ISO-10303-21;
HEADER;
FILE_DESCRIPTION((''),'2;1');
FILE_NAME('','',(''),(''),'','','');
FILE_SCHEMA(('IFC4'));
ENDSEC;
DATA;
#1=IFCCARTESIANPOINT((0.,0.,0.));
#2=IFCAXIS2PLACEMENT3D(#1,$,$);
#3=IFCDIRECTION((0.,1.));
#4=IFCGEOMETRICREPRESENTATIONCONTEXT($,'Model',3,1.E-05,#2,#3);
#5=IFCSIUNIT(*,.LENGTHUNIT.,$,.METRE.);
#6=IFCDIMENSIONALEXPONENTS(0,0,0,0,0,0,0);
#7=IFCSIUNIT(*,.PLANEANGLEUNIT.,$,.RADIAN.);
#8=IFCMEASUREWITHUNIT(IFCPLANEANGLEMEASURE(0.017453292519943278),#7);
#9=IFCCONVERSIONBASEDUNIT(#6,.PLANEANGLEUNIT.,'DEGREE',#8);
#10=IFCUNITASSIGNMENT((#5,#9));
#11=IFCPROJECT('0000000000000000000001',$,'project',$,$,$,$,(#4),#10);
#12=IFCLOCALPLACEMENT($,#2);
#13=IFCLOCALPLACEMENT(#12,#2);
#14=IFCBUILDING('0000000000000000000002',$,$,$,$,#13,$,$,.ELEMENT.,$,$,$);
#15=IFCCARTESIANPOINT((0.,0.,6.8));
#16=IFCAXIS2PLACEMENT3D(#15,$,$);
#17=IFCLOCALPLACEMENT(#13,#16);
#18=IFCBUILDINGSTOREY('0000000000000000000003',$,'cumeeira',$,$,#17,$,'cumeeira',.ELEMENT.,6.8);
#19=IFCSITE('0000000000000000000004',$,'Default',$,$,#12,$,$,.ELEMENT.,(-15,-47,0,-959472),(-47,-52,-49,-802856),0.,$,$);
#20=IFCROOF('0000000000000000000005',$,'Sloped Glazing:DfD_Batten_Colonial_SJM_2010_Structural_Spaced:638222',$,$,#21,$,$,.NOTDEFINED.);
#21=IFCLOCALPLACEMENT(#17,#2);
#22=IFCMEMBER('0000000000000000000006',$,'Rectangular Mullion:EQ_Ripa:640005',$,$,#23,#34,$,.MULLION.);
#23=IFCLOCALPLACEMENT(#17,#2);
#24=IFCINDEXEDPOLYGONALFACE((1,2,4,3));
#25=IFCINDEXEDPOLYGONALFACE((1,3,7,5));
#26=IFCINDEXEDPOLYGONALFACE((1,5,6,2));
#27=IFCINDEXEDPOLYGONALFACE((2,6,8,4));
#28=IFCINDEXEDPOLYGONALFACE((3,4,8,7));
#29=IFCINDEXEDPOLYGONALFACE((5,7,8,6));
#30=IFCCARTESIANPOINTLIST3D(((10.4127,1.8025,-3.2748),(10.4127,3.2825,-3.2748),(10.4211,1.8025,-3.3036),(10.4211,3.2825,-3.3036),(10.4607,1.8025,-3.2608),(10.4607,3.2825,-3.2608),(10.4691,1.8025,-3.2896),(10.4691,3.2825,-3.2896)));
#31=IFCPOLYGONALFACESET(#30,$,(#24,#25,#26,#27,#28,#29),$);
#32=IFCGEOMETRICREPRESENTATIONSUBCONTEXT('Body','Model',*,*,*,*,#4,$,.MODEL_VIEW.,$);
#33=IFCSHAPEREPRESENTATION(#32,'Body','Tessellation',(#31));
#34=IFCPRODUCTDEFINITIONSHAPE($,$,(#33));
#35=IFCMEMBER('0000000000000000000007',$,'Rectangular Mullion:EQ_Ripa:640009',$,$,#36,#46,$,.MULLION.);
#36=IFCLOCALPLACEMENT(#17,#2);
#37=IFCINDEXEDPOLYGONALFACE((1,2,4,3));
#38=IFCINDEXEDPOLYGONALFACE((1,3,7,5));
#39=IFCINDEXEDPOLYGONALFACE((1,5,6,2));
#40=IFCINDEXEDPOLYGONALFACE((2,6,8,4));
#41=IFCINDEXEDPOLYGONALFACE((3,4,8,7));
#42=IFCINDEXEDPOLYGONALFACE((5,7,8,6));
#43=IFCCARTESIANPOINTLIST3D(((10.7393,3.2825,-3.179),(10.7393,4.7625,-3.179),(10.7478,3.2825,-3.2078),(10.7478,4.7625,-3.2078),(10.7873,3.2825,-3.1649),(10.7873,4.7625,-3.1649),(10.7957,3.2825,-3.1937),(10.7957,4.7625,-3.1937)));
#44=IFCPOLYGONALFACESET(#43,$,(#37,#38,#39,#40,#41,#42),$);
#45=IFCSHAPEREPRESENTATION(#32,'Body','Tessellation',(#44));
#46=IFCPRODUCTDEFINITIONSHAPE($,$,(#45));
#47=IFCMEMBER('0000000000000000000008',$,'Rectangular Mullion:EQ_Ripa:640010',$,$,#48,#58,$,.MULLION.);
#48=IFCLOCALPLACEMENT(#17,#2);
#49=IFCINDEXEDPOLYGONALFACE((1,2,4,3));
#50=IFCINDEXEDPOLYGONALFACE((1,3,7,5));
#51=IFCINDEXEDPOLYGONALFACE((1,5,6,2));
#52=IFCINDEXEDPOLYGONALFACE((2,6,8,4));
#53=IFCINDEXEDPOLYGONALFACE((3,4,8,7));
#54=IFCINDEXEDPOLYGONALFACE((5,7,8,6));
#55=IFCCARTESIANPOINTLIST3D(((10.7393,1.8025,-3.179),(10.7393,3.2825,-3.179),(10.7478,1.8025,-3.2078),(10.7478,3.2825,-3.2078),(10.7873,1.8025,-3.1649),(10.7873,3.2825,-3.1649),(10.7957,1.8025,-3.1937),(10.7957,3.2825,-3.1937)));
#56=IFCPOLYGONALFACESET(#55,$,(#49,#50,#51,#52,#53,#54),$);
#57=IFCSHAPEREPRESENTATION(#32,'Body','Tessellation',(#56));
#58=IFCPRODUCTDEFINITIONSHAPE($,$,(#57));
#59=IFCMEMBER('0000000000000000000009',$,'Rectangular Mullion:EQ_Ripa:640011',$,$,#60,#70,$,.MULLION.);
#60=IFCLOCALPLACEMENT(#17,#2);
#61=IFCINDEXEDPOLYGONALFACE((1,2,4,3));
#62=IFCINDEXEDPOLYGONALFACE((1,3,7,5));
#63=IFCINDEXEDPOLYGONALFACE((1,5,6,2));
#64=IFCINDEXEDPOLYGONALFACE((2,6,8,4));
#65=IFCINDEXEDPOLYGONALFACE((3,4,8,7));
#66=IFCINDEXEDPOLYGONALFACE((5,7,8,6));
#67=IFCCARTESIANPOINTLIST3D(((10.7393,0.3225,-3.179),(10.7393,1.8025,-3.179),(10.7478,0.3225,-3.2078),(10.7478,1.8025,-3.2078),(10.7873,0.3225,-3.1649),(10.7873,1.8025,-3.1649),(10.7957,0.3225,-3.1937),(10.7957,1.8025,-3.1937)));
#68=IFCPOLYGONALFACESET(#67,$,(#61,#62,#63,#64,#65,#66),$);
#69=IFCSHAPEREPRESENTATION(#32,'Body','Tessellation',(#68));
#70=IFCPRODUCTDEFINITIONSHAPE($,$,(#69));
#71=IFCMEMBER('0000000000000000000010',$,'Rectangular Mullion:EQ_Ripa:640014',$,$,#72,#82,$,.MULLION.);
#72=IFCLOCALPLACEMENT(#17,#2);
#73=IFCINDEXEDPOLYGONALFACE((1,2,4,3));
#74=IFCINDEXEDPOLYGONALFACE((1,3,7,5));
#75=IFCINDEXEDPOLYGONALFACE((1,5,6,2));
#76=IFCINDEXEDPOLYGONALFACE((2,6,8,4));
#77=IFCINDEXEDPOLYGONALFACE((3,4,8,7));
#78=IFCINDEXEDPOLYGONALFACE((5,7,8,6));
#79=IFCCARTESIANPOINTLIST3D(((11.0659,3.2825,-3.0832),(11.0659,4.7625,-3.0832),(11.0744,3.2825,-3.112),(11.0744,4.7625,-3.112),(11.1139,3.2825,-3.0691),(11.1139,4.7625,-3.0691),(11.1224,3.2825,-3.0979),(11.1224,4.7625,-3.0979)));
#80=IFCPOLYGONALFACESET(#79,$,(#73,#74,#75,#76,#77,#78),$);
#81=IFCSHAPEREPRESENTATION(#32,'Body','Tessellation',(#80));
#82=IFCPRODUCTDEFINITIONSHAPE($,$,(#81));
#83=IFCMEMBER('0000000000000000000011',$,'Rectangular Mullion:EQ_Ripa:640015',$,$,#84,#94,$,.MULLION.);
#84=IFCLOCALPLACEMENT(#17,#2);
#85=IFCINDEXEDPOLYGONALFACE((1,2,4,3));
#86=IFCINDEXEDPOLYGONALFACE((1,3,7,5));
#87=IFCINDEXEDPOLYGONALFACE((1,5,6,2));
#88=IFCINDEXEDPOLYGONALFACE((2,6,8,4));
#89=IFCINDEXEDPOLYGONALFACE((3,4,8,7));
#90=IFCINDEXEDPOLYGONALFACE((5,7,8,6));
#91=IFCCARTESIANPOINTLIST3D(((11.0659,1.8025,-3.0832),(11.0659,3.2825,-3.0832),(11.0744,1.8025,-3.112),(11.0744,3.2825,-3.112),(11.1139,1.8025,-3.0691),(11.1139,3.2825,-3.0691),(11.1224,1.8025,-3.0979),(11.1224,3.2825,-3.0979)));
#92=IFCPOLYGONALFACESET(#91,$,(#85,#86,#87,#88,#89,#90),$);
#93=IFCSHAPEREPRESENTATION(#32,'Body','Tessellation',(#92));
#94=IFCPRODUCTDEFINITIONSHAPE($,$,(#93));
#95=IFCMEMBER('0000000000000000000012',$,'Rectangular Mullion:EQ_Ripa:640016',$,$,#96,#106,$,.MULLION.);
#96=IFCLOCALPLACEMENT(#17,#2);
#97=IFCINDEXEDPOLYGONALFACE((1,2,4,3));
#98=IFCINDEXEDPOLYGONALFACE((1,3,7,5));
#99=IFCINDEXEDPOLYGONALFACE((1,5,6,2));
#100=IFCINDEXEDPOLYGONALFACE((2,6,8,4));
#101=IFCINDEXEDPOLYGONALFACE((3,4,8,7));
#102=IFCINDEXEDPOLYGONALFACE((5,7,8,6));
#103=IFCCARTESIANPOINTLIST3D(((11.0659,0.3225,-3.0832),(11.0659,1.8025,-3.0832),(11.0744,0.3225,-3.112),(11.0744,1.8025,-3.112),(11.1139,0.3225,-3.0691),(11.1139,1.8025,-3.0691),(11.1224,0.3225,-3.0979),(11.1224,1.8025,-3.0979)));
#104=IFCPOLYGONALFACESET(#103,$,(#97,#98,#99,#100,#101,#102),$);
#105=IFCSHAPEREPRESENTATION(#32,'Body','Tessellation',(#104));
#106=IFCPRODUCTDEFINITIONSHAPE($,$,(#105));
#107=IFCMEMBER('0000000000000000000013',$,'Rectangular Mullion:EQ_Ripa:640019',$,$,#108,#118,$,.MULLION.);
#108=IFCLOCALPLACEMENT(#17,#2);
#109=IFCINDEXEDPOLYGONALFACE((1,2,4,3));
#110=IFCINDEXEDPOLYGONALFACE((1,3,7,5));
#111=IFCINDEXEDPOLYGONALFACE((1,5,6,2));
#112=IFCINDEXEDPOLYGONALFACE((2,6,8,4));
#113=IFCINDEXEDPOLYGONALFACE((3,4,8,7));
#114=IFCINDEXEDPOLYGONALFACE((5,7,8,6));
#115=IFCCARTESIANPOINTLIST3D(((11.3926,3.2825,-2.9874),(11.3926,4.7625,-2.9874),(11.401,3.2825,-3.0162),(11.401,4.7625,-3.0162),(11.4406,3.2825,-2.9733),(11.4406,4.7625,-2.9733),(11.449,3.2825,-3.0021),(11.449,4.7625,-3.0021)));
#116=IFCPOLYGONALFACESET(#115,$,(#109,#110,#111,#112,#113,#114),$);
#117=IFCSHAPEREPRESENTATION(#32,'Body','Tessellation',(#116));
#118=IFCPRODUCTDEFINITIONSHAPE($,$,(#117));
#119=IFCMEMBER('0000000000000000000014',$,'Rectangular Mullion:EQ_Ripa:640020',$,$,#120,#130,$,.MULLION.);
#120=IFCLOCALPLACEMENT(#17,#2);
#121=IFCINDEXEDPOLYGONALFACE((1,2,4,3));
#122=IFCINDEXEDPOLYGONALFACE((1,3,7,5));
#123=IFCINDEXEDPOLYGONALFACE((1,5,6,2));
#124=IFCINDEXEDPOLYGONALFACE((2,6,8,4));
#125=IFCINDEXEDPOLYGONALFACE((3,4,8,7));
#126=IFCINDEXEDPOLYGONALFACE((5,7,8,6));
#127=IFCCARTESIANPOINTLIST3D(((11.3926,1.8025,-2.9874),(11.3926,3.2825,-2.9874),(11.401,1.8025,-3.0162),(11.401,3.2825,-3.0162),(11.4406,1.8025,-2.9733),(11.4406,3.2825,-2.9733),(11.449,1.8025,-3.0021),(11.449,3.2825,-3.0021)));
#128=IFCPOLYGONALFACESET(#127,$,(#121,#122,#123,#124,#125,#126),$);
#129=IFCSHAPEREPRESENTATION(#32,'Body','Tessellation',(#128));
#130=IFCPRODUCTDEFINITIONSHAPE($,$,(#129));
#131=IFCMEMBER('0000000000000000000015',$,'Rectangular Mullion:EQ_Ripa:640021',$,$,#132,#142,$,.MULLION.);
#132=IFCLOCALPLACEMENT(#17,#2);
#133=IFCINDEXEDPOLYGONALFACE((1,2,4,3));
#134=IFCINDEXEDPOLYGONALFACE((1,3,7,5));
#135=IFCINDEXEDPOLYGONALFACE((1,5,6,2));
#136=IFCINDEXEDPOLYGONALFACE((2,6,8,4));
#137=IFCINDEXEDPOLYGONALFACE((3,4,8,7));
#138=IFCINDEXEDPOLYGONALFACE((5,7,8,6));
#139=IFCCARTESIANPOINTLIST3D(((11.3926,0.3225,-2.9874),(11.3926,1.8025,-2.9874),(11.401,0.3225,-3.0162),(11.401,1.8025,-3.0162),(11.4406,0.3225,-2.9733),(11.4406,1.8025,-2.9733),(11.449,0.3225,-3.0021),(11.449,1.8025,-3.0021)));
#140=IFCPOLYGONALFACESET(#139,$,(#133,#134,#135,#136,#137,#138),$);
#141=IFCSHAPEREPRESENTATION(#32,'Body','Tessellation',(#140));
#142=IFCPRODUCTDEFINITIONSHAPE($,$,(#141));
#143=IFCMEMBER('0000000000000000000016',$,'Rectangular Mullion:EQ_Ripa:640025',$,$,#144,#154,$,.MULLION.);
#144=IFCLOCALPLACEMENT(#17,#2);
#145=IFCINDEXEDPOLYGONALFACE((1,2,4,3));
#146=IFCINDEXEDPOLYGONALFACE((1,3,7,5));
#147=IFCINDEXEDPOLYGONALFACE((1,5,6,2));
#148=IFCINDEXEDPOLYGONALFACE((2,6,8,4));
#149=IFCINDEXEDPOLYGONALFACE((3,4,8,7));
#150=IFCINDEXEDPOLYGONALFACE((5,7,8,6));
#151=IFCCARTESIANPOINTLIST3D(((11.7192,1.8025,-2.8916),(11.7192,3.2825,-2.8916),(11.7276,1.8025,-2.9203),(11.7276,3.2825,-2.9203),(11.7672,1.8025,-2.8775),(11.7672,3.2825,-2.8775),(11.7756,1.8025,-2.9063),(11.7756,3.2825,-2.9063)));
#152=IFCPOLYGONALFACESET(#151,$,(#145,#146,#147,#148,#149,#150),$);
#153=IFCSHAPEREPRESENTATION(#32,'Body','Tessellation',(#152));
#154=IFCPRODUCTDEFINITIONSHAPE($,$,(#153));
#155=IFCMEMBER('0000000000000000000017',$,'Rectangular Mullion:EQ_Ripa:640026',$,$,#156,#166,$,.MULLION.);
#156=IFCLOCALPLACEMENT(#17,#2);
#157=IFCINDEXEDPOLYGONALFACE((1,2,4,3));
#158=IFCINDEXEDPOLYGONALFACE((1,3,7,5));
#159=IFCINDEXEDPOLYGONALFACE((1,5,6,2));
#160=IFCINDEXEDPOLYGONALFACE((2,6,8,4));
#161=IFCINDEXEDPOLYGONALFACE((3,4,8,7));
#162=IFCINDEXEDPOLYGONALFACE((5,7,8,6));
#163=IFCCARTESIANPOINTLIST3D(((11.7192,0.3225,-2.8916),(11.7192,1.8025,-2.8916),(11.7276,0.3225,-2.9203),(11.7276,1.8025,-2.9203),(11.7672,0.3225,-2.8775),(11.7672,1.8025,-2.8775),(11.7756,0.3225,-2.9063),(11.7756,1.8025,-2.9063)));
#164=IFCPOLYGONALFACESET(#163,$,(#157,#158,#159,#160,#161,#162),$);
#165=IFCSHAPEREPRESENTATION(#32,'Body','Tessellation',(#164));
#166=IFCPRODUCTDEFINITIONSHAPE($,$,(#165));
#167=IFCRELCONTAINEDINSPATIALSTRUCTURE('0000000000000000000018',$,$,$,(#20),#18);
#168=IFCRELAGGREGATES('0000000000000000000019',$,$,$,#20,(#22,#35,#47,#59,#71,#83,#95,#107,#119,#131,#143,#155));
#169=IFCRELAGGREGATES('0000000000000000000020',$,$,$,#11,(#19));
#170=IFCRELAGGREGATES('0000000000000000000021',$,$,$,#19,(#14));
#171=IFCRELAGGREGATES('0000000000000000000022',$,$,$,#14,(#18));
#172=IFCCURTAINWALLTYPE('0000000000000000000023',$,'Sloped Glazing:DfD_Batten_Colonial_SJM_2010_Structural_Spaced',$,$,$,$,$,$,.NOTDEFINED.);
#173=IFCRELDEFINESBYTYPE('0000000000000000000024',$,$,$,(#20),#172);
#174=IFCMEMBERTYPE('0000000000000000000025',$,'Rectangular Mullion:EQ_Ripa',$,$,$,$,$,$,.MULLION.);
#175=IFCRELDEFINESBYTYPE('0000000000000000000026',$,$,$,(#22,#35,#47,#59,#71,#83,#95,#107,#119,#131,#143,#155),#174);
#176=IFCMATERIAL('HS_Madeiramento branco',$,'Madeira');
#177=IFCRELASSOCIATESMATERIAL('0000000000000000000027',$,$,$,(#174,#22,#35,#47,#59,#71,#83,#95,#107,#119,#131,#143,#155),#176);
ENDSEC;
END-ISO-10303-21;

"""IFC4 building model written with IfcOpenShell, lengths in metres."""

from ifc_helpers import new_model, entity, si_unit, converted_unit, direction, frame, origin, place, context, subcontext, project, spatial, indexed_curve, outline, extrude, source, transform, mapped, material, type_object, type_shapes, element, aggregate, save


model = new_model("IFC4")

# Units and contexts
model_context = context("Model", 3, precision=1e-05, world=origin(), true_north=direction((0.0, 1.0)))
body_context = subcontext(model_context, "Body", "Model", "MODEL_VIEW")
ifc_project = project(units=[si_unit("LENGTHUNIT", "METRE"), converted_unit("PLANEANGLEUNIT", "DEGREE", entity("IfcPlaneAngleMeasure", 0.017453292519943278), si_unit("PLANEANGLEUNIT", "RADIAN"), dimensions=[0, 0, 0, 0, 0, 0, 0])], contexts=[model_context])

# Site, building, storey
site_placement = place(None, origin())
site = spatial("IfcSite", under=ifc_project, at=site_placement, Name="Default", CompositionType="ELEMENT", RefLatitude=(-15, -47, 0, -959472), RefLongitude=(-47, -52, -49, -802856), RefElevation=0.0)
building_placement = place(site_placement, origin())
building = spatial("IfcBuilding", under=site, at=building_placement, CompositionType="ELEMENT")
storey_placement = place(building_placement, frame((0.0, 0.0, 6.8)))
storey = spatial("IfcBuildingStorey", under=building, at=storey_placement, Name="cumeeira", LongName="cumeeira", CompositionType="ELEMENT", Elevation=6.8)

# Roof, members
curtain_wall_type = type_object("IfcCurtainWallType", Name="Sloped Glazing:DfD_Batten_Colonial_SJM_2010_Structural_Spaced", PredefinedType="NOTDEFINED")
roof_placement = place(storey_placement, frame((0.0, 0.0, -6.8)))
roof = element("IfcRoof", 1, at=roof_placement, inside=storey, type_object=curtain_wall_type, Name="Sloped Glazing:DfD_Batten_Colonial_SJM_2010_Structural_Spaced:638222", PredefinedType="NOTDEFINED")
ifc_material = material(Name="HS_Madeiramento branco", Category="Madeira")
member_type_1 = type_object("IfcMemberType", Name="Rectangular Mullion:EQ_Ripa", PredefinedType="MULLION", material=ifc_material)
shared_shape_1 = source(origin(), body_context, "Body", "SweptSolid", [
    extrude(outline(indexed_curve([(-0.025, -0.015), (0.025, -0.015), (0.025, 0.015), (-0.025, 0.015), (-0.025, -0.015)], self_intersect=False)), frame((0.0, 0.0, -1.48), z_axis=(0.0, 0.0, 1.0), x_axis=(-1.0, 0.0, 0.0)), (0.0, 0.0, 1.0), 1.48),
])
type_shapes(member_type_1, [shared_shape_1])
member_1_placement = place(roof_placement, frame((10.4409, 3.2825, 3.5178), z_axis=(0.0, 1.0, 0.0), x_axis=(0.95956, 0.0, 0.281504)))
member_1 = element("IfcMember", 2, at=member_1_placement, type_object=member_type_1, material=ifc_material, Name="Rectangular Mullion:EQ_Ripa:640005", PredefinedType="MULLION", context=body_context, shape_type="MappedRepresentation", body=[
    mapped(shared_shape_1, transform((0.0, 0.0, 0.0), scale=1.0)),
])
member_2_placement = place(roof_placement, frame((10.7675, 4.7625, 3.6136), z_axis=(0.0, 1.0, 0.0), x_axis=(0.95956, 0.0, 0.281504)))
member_2 = element("IfcMember", 3, at=member_2_placement, type_object=member_type_1, material=ifc_material, Name="Rectangular Mullion:EQ_Ripa:640009", PredefinedType="MULLION", context=body_context, shape_type="MappedRepresentation", body=[
    mapped(shared_shape_1, transform((0.0, 0.0, 0.0), scale=1.0)),
])
member_3_placement = place(roof_placement, frame((10.7675, 3.2825, 3.6136), z_axis=(0.0, 1.0, 0.0), x_axis=(0.95956, 0.0, 0.281504)))
member_3 = element("IfcMember", 4, at=member_3_placement, type_object=member_type_1, material=ifc_material, Name="Rectangular Mullion:EQ_Ripa:640010", PredefinedType="MULLION", context=body_context, shape_type="MappedRepresentation", body=[
    mapped(shared_shape_1, transform((0.0, 0.0, 0.0), scale=1.0)),
])
member_4_placement = place(roof_placement, frame((10.7675, 1.8025, 3.6136), z_axis=(0.0, 1.0, 0.0), x_axis=(0.95956, 0.0, 0.281504)))
member_4 = element("IfcMember", 5, at=member_4_placement, type_object=member_type_1, material=ifc_material, Name="Rectangular Mullion:EQ_Ripa:640011", PredefinedType="MULLION", context=body_context, shape_type="MappedRepresentation", body=[
    mapped(shared_shape_1, transform((0.0, 0.0, 0.0), scale=1.0)),
])
member_5_placement = place(roof_placement, frame((11.0942, 4.7625, 3.7094), z_axis=(0.0, 1.0, 0.0), x_axis=(0.95956, 0.0, 0.281504)))
member_5 = element("IfcMember", 6, at=member_5_placement, type_object=member_type_1, material=ifc_material, Name="Rectangular Mullion:EQ_Ripa:640014", PredefinedType="MULLION", context=body_context, shape_type="MappedRepresentation", body=[
    mapped(shared_shape_1, transform((0.0, 0.0, 0.0), scale=1.0)),
])
member_6_placement = place(roof_placement, frame((11.0942, 3.2825, 3.7094), z_axis=(0.0, 1.0, 0.0), x_axis=(0.95956, 0.0, 0.281504)))
member_6 = element("IfcMember", 7, at=member_6_placement, type_object=member_type_1, material=ifc_material, Name="Rectangular Mullion:EQ_Ripa:640015", PredefinedType="MULLION", context=body_context, shape_type="MappedRepresentation", body=[
    mapped(shared_shape_1, transform((0.0, 0.0, 0.0), scale=1.0)),
])
member_7_placement = place(roof_placement, frame((11.0942, 1.8025, 3.7094), z_axis=(0.0, 1.0, 0.0), x_axis=(0.95956, 0.0, 0.281504)))
member_7 = element("IfcMember", 8, at=member_7_placement, type_object=member_type_1, material=ifc_material, Name="Rectangular Mullion:EQ_Ripa:640016", PredefinedType="MULLION", context=body_context, shape_type="MappedRepresentation", body=[
    mapped(shared_shape_1, transform((0.0, 0.0, 0.0), scale=1.0)),
])
member_8_placement = place(roof_placement, frame((11.4208, 4.7625, 3.8053), z_axis=(0.0, 1.0, 0.0), x_axis=(0.95956, 0.0, 0.281504)))
member_8 = element("IfcMember", 9, at=member_8_placement, type_object=member_type_1, material=ifc_material, Name="Rectangular Mullion:EQ_Ripa:640019", PredefinedType="MULLION", context=body_context, shape_type="MappedRepresentation", body=[
    mapped(shared_shape_1, transform((0.0, 0.0, 0.0), scale=1.0)),
])
member_9_placement = place(roof_placement, frame((11.4208, 3.2825, 3.8053), z_axis=(0.0, 1.0, 0.0), x_axis=(0.95956, 0.0, 0.281504)))
member_9 = element("IfcMember", 10, at=member_9_placement, type_object=member_type_1, material=ifc_material, Name="Rectangular Mullion:EQ_Ripa:640020", PredefinedType="MULLION", context=body_context, shape_type="MappedRepresentation", body=[
    mapped(shared_shape_1, transform((0.0, 0.0, 0.0), scale=1.0)),
])
member_10_placement = place(roof_placement, frame((11.4208, 1.8025, 3.8053), z_axis=(0.0, 1.0, 0.0), x_axis=(0.95956, 0.0, 0.281504)))
member_10 = element("IfcMember", 11, at=member_10_placement, type_object=member_type_1, material=ifc_material, Name="Rectangular Mullion:EQ_Ripa:640021", PredefinedType="MULLION", context=body_context, shape_type="MappedRepresentation", body=[
    mapped(shared_shape_1, transform((0.0, 0.0, 0.0), scale=1.0)),
])
member_11_placement = place(roof_placement, frame((11.7474, 3.2825, 3.9011), z_axis=(0.0, 1.0, 0.0), x_axis=(0.95956, 0.0, 0.281504)))
member_11 = element("IfcMember", 12, at=member_11_placement, type_object=member_type_1, material=ifc_material, Name="Rectangular Mullion:EQ_Ripa:640025", PredefinedType="MULLION", context=body_context, shape_type="MappedRepresentation", body=[
    mapped(shared_shape_1, transform((0.0, 0.0, 0.0), scale=1.0)),
])
member_12_placement = place(roof_placement, frame((11.7474, 1.8025, 3.9011), z_axis=(0.0, 1.0, 0.0), x_axis=(0.95956, 0.0, 0.281504)))
member_12 = element("IfcMember", 13, at=member_12_placement, type_object=member_type_1, material=ifc_material, Name="Rectangular Mullion:EQ_Ripa:640026", PredefinedType="MULLION", context=body_context, shape_type="MappedRepresentation", body=[
    mapped(shared_shape_1, transform((0.0, 0.0, 0.0), scale=1.0)),
])
aggregate(roof, [member_1, member_2, member_3, member_4, member_5, member_6, member_7, member_8, member_9, member_10, member_11, member_12])

save(model, "model.ifc")
